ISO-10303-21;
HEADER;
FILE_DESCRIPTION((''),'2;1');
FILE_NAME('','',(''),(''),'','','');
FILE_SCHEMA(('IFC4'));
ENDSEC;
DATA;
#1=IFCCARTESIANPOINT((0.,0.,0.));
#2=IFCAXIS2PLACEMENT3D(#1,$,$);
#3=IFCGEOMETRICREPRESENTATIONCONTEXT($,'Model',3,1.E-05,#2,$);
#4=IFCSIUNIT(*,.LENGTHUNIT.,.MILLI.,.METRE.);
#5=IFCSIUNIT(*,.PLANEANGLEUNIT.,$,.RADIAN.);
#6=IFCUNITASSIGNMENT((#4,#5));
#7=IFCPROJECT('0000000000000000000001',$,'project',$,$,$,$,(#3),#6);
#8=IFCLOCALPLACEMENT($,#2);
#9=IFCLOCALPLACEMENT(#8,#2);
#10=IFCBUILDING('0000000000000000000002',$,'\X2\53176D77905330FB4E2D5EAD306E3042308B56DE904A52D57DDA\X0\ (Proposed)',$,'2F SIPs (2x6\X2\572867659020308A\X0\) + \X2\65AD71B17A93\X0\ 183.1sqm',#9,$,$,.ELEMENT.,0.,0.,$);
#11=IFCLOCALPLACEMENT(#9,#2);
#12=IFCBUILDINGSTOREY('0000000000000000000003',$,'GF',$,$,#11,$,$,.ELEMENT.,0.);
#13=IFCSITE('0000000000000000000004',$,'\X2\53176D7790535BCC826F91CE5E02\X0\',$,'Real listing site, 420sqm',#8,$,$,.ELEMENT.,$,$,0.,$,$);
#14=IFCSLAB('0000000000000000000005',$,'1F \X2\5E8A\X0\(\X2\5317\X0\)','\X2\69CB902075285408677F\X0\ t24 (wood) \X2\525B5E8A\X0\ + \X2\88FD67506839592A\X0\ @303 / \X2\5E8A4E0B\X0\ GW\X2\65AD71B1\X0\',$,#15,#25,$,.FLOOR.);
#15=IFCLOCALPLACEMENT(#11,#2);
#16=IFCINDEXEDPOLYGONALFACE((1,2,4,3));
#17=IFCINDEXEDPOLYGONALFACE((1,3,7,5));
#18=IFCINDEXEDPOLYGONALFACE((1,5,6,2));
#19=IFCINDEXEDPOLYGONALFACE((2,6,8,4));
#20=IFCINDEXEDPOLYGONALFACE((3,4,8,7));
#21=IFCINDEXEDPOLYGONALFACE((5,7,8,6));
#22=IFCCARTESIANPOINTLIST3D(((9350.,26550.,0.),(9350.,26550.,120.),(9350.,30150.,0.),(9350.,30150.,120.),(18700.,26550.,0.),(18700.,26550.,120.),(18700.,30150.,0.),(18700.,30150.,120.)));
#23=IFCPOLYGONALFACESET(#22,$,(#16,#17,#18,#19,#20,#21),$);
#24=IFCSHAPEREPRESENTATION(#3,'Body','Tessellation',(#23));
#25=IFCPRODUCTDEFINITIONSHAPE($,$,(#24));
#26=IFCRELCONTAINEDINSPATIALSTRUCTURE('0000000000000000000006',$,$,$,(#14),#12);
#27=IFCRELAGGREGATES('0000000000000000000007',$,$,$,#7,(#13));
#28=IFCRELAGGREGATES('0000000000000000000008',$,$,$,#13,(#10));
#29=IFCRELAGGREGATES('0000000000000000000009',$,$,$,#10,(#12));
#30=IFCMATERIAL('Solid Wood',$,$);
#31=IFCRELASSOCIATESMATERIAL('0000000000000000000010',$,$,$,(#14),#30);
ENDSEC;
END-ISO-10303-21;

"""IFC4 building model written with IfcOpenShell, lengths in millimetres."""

from ifc_helpers import new_model, si_unit, frame, frame_2d, origin, place, context, project, spatial, rectangle, extrude, material, element, save


model = new_model("IFC4")

# Units and contexts
model_context = context("Model", 3, precision=1e-05, world=origin())
ifc_project = project(units=[si_unit("LENGTHUNIT", "METRE", prefix="MILLI"), si_unit("PLANEANGLEUNIT", "RADIAN")], contexts=[model_context])

# Site, building, storey
site_placement = place(None, origin())
site = spatial("IfcSite", under=ifc_project, at=site_placement, Name="北海道富良野市", ObjectType="Real listing site, 420sqm", CompositionType="ELEMENT", RefElevation=0.0)
building_placement = place(site_placement, origin())
building = spatial("IfcBuilding", under=site, at=building_placement, Name="北海道・中庭のある回遊動線 (Proposed)", ObjectType="2F SIPs (2x6在来造り) + 断熱窓 183.1sqm", CompositionType="ELEMENT", ElevationOfRefHeight=0.0, ElevationOfTerrain=0.0)
storey_placement = place(building_placement, origin())
storey = spatial("IfcBuildingStorey", under=building, at=storey_placement, Name="GF", CompositionType="ELEMENT", Elevation=0.0)

# Shared definitions
ifc_material_1 = material(Name="Solid Wood")

# Slab
slab_1_placement = place(storey_placement, frame((4675.0, 13275.0, 0.0)))
element("IfcSlab", 1, at=slab_1_placement, inside=storey, material=ifc_material_1, Name="1F 床(北)", Description="構造用合板 t24 (wood) 剛床 + 製材根太 @303 / 床下 GW断熱", PredefinedType="FLOOR", context=model_context, shape_type="SweptSolid", body=[
    extrude(rectangle(XDim=9350.0, YDim=3600.0, at=frame_2d((4675.0, 1800.0))), frame((4675.0, 13275.0, 0.0)), (0.0, 0.0, 1.0), 120.0),
])

save(model, "model.ifc")
